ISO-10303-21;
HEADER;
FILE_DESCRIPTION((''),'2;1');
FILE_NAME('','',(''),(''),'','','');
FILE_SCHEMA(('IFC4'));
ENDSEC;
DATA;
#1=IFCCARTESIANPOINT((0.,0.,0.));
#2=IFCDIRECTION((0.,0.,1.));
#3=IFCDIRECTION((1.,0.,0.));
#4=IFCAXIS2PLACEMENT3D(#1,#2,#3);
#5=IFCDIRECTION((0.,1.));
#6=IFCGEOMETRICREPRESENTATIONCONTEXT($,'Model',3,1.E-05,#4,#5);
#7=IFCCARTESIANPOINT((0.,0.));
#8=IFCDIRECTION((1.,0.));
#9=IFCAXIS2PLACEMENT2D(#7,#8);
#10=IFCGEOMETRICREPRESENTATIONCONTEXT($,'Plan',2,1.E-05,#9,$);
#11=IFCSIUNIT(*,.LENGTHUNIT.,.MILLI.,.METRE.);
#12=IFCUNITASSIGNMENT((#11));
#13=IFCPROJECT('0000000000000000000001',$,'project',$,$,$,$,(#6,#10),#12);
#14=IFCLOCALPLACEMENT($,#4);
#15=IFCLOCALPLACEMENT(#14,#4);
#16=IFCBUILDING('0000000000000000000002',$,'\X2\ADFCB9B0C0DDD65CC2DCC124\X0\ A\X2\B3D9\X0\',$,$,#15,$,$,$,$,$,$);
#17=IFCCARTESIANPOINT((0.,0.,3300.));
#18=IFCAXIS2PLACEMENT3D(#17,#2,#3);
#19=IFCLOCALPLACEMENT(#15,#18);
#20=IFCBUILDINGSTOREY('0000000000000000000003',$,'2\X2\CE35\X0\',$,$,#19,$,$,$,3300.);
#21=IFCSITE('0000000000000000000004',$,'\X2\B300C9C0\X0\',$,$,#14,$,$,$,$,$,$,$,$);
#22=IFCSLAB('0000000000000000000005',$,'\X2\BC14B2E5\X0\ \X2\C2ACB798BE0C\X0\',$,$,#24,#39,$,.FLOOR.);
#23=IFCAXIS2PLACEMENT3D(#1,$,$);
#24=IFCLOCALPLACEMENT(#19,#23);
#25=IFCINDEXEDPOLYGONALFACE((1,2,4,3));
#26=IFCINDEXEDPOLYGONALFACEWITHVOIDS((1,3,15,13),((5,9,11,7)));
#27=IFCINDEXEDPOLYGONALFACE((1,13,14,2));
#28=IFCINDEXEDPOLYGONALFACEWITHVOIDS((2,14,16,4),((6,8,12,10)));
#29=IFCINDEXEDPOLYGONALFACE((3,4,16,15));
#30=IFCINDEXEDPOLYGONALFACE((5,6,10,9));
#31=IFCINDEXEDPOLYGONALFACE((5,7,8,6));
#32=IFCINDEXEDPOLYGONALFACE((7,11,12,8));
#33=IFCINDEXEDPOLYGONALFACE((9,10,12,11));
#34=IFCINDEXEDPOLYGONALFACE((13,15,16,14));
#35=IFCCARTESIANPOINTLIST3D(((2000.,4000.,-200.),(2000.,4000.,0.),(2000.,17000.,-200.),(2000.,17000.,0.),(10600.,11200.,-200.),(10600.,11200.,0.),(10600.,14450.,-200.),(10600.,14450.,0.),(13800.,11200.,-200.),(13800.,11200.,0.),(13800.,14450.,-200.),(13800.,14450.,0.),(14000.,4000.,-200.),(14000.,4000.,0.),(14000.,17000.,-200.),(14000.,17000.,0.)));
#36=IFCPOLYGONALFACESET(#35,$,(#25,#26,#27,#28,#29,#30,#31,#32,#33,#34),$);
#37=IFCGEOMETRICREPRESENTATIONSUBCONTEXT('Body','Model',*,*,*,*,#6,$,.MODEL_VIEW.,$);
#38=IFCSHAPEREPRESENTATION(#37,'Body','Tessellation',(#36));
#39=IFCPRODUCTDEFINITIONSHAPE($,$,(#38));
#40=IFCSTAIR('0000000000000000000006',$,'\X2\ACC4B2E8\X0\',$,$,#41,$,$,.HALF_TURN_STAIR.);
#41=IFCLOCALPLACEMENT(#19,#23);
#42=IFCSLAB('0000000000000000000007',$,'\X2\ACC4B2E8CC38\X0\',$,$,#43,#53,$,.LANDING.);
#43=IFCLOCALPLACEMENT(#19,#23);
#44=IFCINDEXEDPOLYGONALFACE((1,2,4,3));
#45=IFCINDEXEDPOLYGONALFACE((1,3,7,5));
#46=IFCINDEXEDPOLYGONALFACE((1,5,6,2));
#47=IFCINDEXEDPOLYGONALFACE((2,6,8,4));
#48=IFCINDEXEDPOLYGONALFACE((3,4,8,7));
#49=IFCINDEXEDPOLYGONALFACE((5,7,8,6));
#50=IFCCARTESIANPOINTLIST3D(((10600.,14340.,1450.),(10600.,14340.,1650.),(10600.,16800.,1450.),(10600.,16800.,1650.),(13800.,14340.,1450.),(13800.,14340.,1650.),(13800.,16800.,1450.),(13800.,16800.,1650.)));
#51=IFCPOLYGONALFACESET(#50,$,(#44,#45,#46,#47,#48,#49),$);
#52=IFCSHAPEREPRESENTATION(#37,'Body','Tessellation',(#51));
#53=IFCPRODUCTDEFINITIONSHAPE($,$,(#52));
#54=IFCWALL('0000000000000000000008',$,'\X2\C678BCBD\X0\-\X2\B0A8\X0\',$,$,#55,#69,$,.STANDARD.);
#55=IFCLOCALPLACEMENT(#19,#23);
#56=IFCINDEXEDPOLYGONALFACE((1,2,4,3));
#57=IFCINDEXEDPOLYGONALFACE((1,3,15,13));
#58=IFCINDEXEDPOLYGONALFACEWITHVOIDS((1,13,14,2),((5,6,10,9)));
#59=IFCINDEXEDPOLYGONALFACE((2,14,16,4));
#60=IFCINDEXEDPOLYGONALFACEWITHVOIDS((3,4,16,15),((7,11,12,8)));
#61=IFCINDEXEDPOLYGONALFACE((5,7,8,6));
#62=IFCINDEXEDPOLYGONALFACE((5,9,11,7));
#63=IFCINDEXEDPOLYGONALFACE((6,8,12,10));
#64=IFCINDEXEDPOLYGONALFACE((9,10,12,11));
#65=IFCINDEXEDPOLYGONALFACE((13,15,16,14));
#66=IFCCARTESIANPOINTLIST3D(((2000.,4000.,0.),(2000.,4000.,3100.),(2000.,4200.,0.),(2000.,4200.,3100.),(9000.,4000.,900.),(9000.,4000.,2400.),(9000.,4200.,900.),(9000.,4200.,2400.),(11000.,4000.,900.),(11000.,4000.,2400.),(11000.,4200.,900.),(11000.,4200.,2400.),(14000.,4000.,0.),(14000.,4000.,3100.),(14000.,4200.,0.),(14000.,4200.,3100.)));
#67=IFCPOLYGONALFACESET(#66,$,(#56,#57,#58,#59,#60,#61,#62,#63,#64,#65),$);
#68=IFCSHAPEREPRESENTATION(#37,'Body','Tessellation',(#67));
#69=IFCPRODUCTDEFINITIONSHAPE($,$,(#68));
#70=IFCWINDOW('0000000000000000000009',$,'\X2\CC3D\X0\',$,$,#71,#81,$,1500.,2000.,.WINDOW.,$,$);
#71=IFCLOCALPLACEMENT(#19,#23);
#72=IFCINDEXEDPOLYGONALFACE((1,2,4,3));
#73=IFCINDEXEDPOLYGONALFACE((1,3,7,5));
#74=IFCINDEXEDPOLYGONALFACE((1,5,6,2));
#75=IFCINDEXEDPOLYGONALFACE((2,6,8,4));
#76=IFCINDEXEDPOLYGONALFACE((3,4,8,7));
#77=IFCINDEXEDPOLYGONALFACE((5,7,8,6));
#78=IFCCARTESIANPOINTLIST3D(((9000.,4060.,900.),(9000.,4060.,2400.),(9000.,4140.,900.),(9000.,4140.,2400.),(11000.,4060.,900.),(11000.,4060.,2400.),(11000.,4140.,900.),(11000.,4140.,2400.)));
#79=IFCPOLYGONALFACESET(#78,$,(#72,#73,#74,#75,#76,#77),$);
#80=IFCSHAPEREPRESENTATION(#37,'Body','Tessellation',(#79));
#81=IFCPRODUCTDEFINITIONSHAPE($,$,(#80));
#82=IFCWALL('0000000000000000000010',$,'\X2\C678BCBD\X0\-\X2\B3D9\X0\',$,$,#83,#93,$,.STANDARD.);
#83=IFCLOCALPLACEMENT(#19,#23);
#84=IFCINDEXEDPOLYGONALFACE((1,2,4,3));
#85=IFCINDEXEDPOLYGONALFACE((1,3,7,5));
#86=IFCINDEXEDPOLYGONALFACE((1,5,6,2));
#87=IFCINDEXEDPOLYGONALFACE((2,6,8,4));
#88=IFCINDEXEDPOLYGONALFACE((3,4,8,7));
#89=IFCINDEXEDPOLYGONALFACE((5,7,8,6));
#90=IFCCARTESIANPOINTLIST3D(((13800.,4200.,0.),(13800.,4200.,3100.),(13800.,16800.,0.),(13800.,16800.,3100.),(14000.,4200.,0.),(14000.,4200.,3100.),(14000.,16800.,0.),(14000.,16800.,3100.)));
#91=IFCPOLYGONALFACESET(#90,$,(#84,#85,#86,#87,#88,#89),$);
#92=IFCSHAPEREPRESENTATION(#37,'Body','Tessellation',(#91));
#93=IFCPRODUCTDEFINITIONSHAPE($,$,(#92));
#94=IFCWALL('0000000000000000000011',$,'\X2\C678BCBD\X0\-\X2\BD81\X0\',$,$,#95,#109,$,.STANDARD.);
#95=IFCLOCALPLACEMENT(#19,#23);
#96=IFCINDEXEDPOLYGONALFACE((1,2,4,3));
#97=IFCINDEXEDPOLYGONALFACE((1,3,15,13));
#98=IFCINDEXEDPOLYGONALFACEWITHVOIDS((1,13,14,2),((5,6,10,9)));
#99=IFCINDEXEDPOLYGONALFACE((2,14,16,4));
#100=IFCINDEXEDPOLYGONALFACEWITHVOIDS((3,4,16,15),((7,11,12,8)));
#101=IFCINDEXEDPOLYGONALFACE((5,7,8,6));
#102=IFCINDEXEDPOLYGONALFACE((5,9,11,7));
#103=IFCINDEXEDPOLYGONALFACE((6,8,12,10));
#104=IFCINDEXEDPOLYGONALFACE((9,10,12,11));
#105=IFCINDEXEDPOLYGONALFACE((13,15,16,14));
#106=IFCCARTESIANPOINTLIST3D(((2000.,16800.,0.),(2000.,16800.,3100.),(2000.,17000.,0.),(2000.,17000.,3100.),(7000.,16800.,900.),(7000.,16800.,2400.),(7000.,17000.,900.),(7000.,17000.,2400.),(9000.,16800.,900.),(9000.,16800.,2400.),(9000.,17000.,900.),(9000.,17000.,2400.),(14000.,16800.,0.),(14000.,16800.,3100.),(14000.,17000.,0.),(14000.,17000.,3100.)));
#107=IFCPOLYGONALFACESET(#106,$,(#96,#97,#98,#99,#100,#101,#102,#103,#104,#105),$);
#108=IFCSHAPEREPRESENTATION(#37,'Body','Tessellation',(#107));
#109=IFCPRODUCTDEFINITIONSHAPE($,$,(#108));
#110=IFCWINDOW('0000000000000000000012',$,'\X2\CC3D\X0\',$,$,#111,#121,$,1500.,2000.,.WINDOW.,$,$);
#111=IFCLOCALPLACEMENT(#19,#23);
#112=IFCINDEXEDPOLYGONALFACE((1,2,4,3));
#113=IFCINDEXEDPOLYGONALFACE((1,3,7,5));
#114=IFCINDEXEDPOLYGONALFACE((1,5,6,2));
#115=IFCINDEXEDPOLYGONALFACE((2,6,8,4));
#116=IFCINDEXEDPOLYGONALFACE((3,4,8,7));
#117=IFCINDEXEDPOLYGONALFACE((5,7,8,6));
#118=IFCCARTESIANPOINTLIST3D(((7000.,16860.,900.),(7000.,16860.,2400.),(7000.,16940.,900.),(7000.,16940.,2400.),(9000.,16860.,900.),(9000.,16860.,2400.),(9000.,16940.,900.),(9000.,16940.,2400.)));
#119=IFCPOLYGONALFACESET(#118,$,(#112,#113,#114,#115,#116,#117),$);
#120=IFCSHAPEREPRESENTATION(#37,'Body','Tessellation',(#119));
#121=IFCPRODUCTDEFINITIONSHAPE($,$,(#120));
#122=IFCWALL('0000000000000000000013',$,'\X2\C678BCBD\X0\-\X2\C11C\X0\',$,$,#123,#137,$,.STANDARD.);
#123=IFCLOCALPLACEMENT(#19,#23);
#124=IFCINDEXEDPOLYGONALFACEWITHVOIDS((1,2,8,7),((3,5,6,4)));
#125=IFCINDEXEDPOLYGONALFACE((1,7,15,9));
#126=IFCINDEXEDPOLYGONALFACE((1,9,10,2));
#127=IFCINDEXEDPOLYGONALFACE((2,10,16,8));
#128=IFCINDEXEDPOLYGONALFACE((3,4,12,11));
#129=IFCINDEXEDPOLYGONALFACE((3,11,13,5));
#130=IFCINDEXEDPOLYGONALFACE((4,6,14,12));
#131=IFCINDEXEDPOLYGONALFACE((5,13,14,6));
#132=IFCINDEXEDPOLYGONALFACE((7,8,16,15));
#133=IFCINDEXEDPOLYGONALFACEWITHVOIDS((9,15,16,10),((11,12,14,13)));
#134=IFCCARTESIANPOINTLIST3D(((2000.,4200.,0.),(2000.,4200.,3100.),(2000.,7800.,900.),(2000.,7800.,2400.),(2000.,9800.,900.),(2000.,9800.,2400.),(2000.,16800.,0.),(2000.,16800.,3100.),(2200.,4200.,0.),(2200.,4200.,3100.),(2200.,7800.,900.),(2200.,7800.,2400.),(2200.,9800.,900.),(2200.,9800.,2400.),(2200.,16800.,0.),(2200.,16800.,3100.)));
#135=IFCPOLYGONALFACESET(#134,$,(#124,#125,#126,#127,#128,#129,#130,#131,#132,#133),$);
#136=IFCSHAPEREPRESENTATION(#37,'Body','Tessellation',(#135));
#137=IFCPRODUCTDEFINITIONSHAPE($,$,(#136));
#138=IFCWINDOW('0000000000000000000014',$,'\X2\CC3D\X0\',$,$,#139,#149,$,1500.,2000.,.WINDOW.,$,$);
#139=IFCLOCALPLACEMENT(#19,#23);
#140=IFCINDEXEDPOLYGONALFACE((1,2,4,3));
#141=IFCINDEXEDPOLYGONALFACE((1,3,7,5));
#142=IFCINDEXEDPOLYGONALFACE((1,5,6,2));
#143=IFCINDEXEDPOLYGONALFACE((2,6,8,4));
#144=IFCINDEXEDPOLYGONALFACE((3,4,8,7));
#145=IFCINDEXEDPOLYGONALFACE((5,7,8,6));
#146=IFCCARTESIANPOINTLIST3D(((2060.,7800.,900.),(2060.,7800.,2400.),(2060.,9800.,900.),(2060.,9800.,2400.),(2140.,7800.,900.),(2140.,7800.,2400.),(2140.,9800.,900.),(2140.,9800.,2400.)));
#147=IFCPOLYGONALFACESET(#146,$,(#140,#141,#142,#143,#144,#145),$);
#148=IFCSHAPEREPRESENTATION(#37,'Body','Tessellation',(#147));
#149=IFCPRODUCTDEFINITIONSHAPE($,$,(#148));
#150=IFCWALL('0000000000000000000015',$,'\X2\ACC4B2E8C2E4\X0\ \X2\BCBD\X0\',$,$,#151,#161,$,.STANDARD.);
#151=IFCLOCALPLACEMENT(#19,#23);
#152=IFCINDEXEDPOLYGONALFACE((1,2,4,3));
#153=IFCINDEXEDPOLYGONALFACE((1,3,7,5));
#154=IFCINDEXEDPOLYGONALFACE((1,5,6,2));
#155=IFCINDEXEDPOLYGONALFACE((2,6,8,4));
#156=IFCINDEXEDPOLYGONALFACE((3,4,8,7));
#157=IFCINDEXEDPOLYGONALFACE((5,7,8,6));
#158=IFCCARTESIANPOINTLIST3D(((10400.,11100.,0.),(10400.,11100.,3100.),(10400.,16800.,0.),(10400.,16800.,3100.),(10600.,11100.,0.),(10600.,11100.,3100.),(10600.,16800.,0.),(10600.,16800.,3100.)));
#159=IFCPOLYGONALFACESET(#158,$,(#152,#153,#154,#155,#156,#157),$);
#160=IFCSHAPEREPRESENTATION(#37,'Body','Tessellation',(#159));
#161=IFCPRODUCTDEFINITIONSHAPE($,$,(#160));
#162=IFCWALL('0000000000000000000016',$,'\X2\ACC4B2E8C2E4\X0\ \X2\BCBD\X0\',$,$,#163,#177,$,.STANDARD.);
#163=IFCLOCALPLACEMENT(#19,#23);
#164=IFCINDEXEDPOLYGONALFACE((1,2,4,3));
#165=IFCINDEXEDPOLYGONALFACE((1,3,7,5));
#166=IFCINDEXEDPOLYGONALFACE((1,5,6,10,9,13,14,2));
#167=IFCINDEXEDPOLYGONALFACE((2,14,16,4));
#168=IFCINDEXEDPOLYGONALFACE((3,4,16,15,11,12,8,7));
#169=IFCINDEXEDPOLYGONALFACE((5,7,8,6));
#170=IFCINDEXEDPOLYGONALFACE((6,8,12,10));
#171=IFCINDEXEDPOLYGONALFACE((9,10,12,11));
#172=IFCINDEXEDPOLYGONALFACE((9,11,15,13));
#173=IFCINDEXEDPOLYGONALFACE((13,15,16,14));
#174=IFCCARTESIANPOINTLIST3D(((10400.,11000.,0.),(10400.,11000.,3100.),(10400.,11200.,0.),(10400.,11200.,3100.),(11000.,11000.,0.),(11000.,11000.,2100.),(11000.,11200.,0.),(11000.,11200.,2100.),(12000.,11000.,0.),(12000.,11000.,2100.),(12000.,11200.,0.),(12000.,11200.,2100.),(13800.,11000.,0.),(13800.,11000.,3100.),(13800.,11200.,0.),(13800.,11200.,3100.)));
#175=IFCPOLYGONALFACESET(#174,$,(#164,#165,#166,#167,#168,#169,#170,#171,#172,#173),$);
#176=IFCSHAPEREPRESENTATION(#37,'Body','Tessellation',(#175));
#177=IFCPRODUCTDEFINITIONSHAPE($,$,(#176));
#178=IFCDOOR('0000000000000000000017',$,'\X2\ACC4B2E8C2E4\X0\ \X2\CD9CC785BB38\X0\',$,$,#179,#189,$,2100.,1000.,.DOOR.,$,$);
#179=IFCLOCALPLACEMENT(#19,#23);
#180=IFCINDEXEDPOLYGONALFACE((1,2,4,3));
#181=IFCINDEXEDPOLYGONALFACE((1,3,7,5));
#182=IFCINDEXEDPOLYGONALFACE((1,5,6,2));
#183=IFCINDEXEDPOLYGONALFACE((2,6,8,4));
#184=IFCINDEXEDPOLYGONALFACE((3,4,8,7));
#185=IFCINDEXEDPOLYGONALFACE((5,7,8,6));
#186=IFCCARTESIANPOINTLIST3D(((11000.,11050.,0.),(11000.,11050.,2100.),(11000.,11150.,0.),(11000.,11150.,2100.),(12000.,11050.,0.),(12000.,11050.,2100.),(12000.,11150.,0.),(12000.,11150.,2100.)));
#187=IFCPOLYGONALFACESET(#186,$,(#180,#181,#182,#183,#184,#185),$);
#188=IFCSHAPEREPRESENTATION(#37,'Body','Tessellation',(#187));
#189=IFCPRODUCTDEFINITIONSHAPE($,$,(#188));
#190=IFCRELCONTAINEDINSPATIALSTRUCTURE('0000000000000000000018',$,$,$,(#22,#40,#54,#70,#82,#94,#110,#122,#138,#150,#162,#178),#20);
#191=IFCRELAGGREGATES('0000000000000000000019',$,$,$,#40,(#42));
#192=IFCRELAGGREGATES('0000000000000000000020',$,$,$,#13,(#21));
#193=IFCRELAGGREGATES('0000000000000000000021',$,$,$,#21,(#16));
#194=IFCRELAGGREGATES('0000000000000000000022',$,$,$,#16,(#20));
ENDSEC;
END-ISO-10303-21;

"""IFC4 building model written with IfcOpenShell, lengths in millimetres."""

from ifc_helpers import new_model, si_unit, direction, frame, origin_with_axes, origin_2d_with_axis, place, context, subcontext, project, spatial, polyline, outline, extrude, element, fill, aggregate, save


model = new_model("IFC4")

# Units and contexts
model_context = context("Model", 3, precision=1e-05, world=origin_with_axes(), true_north=direction((0.0, 1.0)))
plan_context = context("Plan", 2, precision=1e-05, world=origin_2d_with_axis())
body_context = subcontext(model_context, "Body", "Model", "MODEL_VIEW")
ifc_project = project(units=[si_unit("LENGTHUNIT", "METRE", prefix="MILLI")], contexts=[model_context, plan_context])

# Site, building, storey
site_placement = place(None, origin_with_axes())
site = spatial("IfcSite", under=ifc_project, at=site_placement, Name="대지")
building_placement = place(site_placement, origin_with_axes())
building = spatial("IfcBuilding", under=site, at=building_placement, Name="근린생활시설 A동")
storey_placement = place(building_placement, frame((0.0, 0.0, 3300.0), z_axis=(0.0, 0.0, 1.0), x_axis=(1.0, 0.0, 0.0)))
storey = spatial("IfcBuildingStorey", under=building, at=storey_placement, Name="2층", Elevation=3300.0)

# Slab
slab_1_placement = place(storey_placement, origin_with_axes())
element("IfcSlab", 1, at=slab_1_placement, inside=storey, Name="바닥 슬래브", PredefinedType="FLOOR", context=body_context, shape_type="SweptSolid", body=[
    extrude(outline(polyline([(2000.0, 4000.0), (14000.0, 4000.0), (14000.0, 17000.0), (2000.0, 17000.0), (2000.0, 4000.0)]), holes=[polyline([(10600.0, 11200.0), (13800.0, 11200.0), (13800.0, 14450.0), (10600.0, 14450.0), (10600.0, 11200.0)])]), frame((0.0, 0.0, -200.0), z_axis=(0.0, 0.0, 1.0), x_axis=(1.0, 0.0, 0.0)), (0.0, 0.0, 1.0), 200.0),
])

# Stair, slab
stair_placement = place(storey_placement, origin_with_axes())
stair = element("IfcStair", 2, at=stair_placement, inside=storey, Name="계단", PredefinedType="HALF_TURN_STAIR")
slab_2_placement = place(stair_placement, origin_with_axes())
slab_2 = element("IfcSlab", 3, at=slab_2_placement, Name="계단참", PredefinedType="LANDING", context=body_context, shape_type="SweptSolid", body=[
    extrude(outline(polyline([(10600.0, 14340.0), (13800.0, 14340.0), (13800.0, 16800.0), (10600.0, 16800.0), (10600.0, 14340.0)])), frame((0.0, 0.0, 1450.0), z_axis=(0.0, 0.0, 1.0), x_axis=(1.0, 0.0, 0.0)), (0.0, 0.0, 1.0), 200.0),
])

# Wall, opening, window
wall_1_placement = place(storey_placement, origin_with_axes())
wall_1 = element("IfcWall", 4, at=wall_1_placement, inside=storey, Name="외벽-남", PredefinedType="STANDARD", context=body_context, shape_type="SweptSolid", body=[
    extrude(outline(polyline([(2000.0, 4200.0), (14000.0, 4200.0), (14000.0, 4000.0), (2000.0, 4000.0), (2000.0, 4200.0)])), origin_with_axes(), (0.0, 0.0, 1.0), 3100.0),
])
opening_1_placement = place(storey_placement, origin_with_axes())
opening_1 = element("IfcOpeningElement", 5, at=opening_1_placement, cuts=wall_1, PredefinedType="OPENING", context=body_context, shape_type="SweptSolid", body=[
    extrude(outline(polyline([(9000.0, 3950.0), (11000.0, 3950.0), (11000.0, 4250.0), (9000.0, 4250.0), (9000.0, 3950.0)])), frame((0.0, 0.0, 900.0), z_axis=(0.0, 0.0, 1.0), x_axis=(1.0, 0.0, 0.0)), (0.0, 0.0, 1.0), 1500.0),
])
window_1_placement = place(storey_placement, origin_with_axes())
window_1 = element("IfcWindow", 6, at=window_1_placement, inside=storey, Name="창", OverallHeight=1500.0, OverallWidth=2000.0, PredefinedType="WINDOW", context=body_context, shape_type="SweptSolid", body=[
    extrude(outline(polyline([(9000.0, 4060.0), (11000.0, 4060.0), (11000.0, 4140.0), (9000.0, 4140.0), (9000.0, 4060.0)])), frame((0.0, 0.0, 900.0), z_axis=(0.0, 0.0, 1.0), x_axis=(1.0, 0.0, 0.0)), (0.0, 0.0, 1.0), 1500.0),
])
fill(opening_1, window_1)

# Wall
wall_2_placement = place(storey_placement, origin_with_axes())
element("IfcWall", 7, at=wall_2_placement, inside=storey, Name="외벽-동", PredefinedType="STANDARD", context=body_context, shape_type="SweptSolid", body=[
    extrude(outline(polyline([(13800.0, 4200.0), (13800.0, 16800.0), (14000.0, 16800.0), (14000.0, 4200.0), (13800.0, 4200.0)])), origin_with_axes(), (0.0, 0.0, 1.0), 3100.0),
])

# Walls, openings, windows
wall_3_placement = place(storey_placement, origin_with_axes())
wall_3 = element("IfcWall", 8, at=wall_3_placement, inside=storey, Name="외벽-북", PredefinedType="STANDARD", context=body_context, shape_type="SweptSolid", body=[
    extrude(outline(polyline([(14000.0, 16800.0), (2000.0, 16800.0), (2000.0, 17000.0), (14000.0, 17000.0), (14000.0, 16800.0)])), origin_with_axes(), (0.0, 0.0, 1.0), 3100.0),
])
opening_2_placement = place(storey_placement, origin_with_axes())
opening_2 = element("IfcOpeningElement", 9, at=opening_2_placement, cuts=wall_3, PredefinedType="OPENING", context=body_context, shape_type="SweptSolid", body=[
    extrude(outline(polyline([(9000.0, 17050.0), (7000.0, 17050.0), (7000.0, 16750.0), (9000.0, 16750.0), (9000.0, 17050.0)])), frame((0.0, 0.0, 900.0), z_axis=(0.0, 0.0, 1.0), x_axis=(1.0, 0.0, 0.0)), (0.0, 0.0, 1.0), 1500.0),
])
window_2_placement = place(storey_placement, origin_with_axes())
window_2 = element("IfcWindow", 10, at=window_2_placement, inside=storey, Name="창", OverallHeight=1500.0, OverallWidth=2000.0, PredefinedType="WINDOW", context=body_context, shape_type="SweptSolid", body=[
    extrude(outline(polyline([(9000.0, 16940.0), (7000.0, 16940.0), (7000.0, 16860.0), (9000.0, 16860.0), (9000.0, 16940.0)])), frame((0.0, 0.0, 900.0), z_axis=(0.0, 0.0, 1.0), x_axis=(1.0, 0.0, 0.0)), (0.0, 0.0, 1.0), 1500.0),
])
fill(opening_2, window_2)
wall_4_placement = place(storey_placement, origin_with_axes())
wall_4 = element("IfcWall", 11, at=wall_4_placement, inside=storey, Name="외벽-서", PredefinedType="STANDARD", context=body_context, shape_type="SweptSolid", body=[
    extrude(outline(polyline([(2200.0, 16800.0), (2200.0, 4200.0), (2000.0, 4200.0), (2000.0, 16800.0), (2200.0, 16800.0)])), origin_with_axes(), (0.0, 0.0, 1.0), 3100.0),
])
opening_3_placement = place(storey_placement, origin_with_axes())
opening_3 = element("IfcOpeningElement", 12, at=opening_3_placement, cuts=wall_4, PredefinedType="OPENING", context=body_context, shape_type="SweptSolid", body=[
    extrude(outline(polyline([(1950.0, 9800.0), (1950.0, 7800.0), (2250.0, 7800.0), (2250.0, 9800.0), (1950.0, 9800.0)])), frame((0.0, 0.0, 900.0), z_axis=(0.0, 0.0, 1.0), x_axis=(1.0, 0.0, 0.0)), (0.0, 0.0, 1.0), 1500.0),
])
window_3_placement = place(storey_placement, origin_with_axes())
window_3 = element("IfcWindow", 13, at=window_3_placement, inside=storey, Name="창", OverallHeight=1500.0, OverallWidth=2000.0, PredefinedType="WINDOW", context=body_context, shape_type="SweptSolid", body=[
    extrude(outline(polyline([(2060.0, 9800.0), (2060.0, 7800.0), (2140.0, 7800.0), (2140.0, 9800.0), (2060.0, 9800.0)])), frame((0.0, 0.0, 900.0), z_axis=(0.0, 0.0, 1.0), x_axis=(1.0, 0.0, 0.0)), (0.0, 0.0, 1.0), 1500.0),
])
fill(opening_3, window_3)

# Wall
wall_5_placement = place(storey_placement, origin_with_axes())
element("IfcWall", 14, at=wall_5_placement, inside=storey, Name="계단실 벽", PredefinedType="STANDARD", context=body_context, shape_type="SweptSolid", body=[
    extrude(outline(polyline([(10400.0, 11100.0), (10400.0, 16800.0), (10600.0, 16800.0), (10600.0, 11100.0), (10400.0, 11100.0)])), origin_with_axes(), (0.0, 0.0, 1.0), 3100.0),
])

# Wall, opening, door
wall_6_placement = place(storey_placement, origin_with_axes())
wall_6 = element("IfcWall", 15, at=wall_6_placement, inside=storey, Name="계단실 벽", PredefinedType="STANDARD", context=body_context, shape_type="SweptSolid", body=[
    extrude(outline(polyline([(10400.0, 11200.0), (13800.0, 11200.0), (13800.0, 11000.0), (10400.0, 11000.0), (10400.0, 11200.0)])), origin_with_axes(), (0.0, 0.0, 1.0), 3100.0),
])
opening_4_placement = place(storey_placement, origin_with_axes())
opening_4 = element("IfcOpeningElement", 16, at=opening_4_placement, cuts=wall_6, PredefinedType="OPENING", context=body_context, shape_type="SweptSolid", body=[
    extrude(outline(polyline([(11000.0, 10950.0), (12000.0, 10950.0), (12000.0, 11250.0), (11000.0, 11250.0), (11000.0, 10950.0)])), origin_with_axes(), (0.0, 0.0, 1.0), 2100.0),
])
door_1_placement = place(storey_placement, origin_with_axes())
door_1 = element("IfcDoor", 17, at=door_1_placement, inside=storey, Name="계단실 출입문", OverallHeight=2100.0, OverallWidth=1000.0, PredefinedType="DOOR", context=body_context, shape_type="SweptSolid", body=[
    extrude(outline(polyline([(11000.0, 11050.0), (12000.0, 11050.0), (12000.0, 11150.0), (11000.0, 11150.0), (11000.0, 11050.0)])), origin_with_axes(), (0.0, 0.0, 1.0), 2100.0),
])
fill(opening_4, door_1)

aggregate(stair, [slab_2])

save(model, "model.ifc")
